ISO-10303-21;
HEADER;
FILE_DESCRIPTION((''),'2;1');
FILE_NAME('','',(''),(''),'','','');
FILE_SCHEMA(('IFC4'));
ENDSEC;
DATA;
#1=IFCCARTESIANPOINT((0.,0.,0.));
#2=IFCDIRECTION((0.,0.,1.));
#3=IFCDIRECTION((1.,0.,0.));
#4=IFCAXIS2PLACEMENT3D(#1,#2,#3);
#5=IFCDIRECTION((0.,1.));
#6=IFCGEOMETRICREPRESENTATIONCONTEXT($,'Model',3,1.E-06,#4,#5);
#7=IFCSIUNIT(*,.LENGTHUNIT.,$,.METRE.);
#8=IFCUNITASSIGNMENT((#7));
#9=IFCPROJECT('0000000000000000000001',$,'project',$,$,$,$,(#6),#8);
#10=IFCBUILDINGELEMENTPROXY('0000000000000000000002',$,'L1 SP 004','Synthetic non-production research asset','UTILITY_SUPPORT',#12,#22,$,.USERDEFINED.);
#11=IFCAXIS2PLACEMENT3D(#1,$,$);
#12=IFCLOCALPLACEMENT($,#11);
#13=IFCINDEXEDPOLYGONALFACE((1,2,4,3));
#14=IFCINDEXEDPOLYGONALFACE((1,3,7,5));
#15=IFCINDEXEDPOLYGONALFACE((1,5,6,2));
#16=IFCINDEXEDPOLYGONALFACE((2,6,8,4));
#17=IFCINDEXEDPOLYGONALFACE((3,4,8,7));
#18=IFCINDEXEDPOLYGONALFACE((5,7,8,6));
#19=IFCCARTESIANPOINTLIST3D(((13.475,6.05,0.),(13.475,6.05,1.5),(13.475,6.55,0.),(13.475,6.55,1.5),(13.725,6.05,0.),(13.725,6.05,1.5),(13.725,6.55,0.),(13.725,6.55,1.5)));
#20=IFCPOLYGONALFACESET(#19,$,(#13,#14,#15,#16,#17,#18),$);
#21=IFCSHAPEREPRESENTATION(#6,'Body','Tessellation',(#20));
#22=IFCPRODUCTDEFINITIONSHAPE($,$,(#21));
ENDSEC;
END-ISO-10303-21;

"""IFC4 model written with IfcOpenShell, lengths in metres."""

from ifc_helpers import new_model, si_unit, direction, frame, origin_with_axes, origin_2d_with_axis, place, context, project, rectangle, extrude, element, save


model = new_model("IFC4")

# Units and contexts
model_context = context("Model", 3, precision=1e-06, world=origin_with_axes(), true_north=direction((0.0, 1.0)))
ifc_project = project(units=[si_unit("LENGTHUNIT", "METRE")], contexts=[model_context])

# Building element proxy
proxy_placement = place(None, frame((13.6, 6.3, 0.0), z_axis=(0.0, 0.0, 1.0), x_axis=(1.0, 0.0, 0.0)))
element("IfcBuildingElementProxy", 1, at=proxy_placement, Name="L1 SP 004", Description="Synthetic non-production research asset", ObjectType="UTILITY_SUPPORT", PredefinedType="USERDEFINED", context=model_context, shape_type="SweptSolid", body=[
    extrude(rectangle(XDim=0.25, YDim=0.5, at=origin_2d_with_axis()), origin_with_axes(), (0.0, 0.0, 1.0), 1.5),
])

save(model, "model.ifc")
